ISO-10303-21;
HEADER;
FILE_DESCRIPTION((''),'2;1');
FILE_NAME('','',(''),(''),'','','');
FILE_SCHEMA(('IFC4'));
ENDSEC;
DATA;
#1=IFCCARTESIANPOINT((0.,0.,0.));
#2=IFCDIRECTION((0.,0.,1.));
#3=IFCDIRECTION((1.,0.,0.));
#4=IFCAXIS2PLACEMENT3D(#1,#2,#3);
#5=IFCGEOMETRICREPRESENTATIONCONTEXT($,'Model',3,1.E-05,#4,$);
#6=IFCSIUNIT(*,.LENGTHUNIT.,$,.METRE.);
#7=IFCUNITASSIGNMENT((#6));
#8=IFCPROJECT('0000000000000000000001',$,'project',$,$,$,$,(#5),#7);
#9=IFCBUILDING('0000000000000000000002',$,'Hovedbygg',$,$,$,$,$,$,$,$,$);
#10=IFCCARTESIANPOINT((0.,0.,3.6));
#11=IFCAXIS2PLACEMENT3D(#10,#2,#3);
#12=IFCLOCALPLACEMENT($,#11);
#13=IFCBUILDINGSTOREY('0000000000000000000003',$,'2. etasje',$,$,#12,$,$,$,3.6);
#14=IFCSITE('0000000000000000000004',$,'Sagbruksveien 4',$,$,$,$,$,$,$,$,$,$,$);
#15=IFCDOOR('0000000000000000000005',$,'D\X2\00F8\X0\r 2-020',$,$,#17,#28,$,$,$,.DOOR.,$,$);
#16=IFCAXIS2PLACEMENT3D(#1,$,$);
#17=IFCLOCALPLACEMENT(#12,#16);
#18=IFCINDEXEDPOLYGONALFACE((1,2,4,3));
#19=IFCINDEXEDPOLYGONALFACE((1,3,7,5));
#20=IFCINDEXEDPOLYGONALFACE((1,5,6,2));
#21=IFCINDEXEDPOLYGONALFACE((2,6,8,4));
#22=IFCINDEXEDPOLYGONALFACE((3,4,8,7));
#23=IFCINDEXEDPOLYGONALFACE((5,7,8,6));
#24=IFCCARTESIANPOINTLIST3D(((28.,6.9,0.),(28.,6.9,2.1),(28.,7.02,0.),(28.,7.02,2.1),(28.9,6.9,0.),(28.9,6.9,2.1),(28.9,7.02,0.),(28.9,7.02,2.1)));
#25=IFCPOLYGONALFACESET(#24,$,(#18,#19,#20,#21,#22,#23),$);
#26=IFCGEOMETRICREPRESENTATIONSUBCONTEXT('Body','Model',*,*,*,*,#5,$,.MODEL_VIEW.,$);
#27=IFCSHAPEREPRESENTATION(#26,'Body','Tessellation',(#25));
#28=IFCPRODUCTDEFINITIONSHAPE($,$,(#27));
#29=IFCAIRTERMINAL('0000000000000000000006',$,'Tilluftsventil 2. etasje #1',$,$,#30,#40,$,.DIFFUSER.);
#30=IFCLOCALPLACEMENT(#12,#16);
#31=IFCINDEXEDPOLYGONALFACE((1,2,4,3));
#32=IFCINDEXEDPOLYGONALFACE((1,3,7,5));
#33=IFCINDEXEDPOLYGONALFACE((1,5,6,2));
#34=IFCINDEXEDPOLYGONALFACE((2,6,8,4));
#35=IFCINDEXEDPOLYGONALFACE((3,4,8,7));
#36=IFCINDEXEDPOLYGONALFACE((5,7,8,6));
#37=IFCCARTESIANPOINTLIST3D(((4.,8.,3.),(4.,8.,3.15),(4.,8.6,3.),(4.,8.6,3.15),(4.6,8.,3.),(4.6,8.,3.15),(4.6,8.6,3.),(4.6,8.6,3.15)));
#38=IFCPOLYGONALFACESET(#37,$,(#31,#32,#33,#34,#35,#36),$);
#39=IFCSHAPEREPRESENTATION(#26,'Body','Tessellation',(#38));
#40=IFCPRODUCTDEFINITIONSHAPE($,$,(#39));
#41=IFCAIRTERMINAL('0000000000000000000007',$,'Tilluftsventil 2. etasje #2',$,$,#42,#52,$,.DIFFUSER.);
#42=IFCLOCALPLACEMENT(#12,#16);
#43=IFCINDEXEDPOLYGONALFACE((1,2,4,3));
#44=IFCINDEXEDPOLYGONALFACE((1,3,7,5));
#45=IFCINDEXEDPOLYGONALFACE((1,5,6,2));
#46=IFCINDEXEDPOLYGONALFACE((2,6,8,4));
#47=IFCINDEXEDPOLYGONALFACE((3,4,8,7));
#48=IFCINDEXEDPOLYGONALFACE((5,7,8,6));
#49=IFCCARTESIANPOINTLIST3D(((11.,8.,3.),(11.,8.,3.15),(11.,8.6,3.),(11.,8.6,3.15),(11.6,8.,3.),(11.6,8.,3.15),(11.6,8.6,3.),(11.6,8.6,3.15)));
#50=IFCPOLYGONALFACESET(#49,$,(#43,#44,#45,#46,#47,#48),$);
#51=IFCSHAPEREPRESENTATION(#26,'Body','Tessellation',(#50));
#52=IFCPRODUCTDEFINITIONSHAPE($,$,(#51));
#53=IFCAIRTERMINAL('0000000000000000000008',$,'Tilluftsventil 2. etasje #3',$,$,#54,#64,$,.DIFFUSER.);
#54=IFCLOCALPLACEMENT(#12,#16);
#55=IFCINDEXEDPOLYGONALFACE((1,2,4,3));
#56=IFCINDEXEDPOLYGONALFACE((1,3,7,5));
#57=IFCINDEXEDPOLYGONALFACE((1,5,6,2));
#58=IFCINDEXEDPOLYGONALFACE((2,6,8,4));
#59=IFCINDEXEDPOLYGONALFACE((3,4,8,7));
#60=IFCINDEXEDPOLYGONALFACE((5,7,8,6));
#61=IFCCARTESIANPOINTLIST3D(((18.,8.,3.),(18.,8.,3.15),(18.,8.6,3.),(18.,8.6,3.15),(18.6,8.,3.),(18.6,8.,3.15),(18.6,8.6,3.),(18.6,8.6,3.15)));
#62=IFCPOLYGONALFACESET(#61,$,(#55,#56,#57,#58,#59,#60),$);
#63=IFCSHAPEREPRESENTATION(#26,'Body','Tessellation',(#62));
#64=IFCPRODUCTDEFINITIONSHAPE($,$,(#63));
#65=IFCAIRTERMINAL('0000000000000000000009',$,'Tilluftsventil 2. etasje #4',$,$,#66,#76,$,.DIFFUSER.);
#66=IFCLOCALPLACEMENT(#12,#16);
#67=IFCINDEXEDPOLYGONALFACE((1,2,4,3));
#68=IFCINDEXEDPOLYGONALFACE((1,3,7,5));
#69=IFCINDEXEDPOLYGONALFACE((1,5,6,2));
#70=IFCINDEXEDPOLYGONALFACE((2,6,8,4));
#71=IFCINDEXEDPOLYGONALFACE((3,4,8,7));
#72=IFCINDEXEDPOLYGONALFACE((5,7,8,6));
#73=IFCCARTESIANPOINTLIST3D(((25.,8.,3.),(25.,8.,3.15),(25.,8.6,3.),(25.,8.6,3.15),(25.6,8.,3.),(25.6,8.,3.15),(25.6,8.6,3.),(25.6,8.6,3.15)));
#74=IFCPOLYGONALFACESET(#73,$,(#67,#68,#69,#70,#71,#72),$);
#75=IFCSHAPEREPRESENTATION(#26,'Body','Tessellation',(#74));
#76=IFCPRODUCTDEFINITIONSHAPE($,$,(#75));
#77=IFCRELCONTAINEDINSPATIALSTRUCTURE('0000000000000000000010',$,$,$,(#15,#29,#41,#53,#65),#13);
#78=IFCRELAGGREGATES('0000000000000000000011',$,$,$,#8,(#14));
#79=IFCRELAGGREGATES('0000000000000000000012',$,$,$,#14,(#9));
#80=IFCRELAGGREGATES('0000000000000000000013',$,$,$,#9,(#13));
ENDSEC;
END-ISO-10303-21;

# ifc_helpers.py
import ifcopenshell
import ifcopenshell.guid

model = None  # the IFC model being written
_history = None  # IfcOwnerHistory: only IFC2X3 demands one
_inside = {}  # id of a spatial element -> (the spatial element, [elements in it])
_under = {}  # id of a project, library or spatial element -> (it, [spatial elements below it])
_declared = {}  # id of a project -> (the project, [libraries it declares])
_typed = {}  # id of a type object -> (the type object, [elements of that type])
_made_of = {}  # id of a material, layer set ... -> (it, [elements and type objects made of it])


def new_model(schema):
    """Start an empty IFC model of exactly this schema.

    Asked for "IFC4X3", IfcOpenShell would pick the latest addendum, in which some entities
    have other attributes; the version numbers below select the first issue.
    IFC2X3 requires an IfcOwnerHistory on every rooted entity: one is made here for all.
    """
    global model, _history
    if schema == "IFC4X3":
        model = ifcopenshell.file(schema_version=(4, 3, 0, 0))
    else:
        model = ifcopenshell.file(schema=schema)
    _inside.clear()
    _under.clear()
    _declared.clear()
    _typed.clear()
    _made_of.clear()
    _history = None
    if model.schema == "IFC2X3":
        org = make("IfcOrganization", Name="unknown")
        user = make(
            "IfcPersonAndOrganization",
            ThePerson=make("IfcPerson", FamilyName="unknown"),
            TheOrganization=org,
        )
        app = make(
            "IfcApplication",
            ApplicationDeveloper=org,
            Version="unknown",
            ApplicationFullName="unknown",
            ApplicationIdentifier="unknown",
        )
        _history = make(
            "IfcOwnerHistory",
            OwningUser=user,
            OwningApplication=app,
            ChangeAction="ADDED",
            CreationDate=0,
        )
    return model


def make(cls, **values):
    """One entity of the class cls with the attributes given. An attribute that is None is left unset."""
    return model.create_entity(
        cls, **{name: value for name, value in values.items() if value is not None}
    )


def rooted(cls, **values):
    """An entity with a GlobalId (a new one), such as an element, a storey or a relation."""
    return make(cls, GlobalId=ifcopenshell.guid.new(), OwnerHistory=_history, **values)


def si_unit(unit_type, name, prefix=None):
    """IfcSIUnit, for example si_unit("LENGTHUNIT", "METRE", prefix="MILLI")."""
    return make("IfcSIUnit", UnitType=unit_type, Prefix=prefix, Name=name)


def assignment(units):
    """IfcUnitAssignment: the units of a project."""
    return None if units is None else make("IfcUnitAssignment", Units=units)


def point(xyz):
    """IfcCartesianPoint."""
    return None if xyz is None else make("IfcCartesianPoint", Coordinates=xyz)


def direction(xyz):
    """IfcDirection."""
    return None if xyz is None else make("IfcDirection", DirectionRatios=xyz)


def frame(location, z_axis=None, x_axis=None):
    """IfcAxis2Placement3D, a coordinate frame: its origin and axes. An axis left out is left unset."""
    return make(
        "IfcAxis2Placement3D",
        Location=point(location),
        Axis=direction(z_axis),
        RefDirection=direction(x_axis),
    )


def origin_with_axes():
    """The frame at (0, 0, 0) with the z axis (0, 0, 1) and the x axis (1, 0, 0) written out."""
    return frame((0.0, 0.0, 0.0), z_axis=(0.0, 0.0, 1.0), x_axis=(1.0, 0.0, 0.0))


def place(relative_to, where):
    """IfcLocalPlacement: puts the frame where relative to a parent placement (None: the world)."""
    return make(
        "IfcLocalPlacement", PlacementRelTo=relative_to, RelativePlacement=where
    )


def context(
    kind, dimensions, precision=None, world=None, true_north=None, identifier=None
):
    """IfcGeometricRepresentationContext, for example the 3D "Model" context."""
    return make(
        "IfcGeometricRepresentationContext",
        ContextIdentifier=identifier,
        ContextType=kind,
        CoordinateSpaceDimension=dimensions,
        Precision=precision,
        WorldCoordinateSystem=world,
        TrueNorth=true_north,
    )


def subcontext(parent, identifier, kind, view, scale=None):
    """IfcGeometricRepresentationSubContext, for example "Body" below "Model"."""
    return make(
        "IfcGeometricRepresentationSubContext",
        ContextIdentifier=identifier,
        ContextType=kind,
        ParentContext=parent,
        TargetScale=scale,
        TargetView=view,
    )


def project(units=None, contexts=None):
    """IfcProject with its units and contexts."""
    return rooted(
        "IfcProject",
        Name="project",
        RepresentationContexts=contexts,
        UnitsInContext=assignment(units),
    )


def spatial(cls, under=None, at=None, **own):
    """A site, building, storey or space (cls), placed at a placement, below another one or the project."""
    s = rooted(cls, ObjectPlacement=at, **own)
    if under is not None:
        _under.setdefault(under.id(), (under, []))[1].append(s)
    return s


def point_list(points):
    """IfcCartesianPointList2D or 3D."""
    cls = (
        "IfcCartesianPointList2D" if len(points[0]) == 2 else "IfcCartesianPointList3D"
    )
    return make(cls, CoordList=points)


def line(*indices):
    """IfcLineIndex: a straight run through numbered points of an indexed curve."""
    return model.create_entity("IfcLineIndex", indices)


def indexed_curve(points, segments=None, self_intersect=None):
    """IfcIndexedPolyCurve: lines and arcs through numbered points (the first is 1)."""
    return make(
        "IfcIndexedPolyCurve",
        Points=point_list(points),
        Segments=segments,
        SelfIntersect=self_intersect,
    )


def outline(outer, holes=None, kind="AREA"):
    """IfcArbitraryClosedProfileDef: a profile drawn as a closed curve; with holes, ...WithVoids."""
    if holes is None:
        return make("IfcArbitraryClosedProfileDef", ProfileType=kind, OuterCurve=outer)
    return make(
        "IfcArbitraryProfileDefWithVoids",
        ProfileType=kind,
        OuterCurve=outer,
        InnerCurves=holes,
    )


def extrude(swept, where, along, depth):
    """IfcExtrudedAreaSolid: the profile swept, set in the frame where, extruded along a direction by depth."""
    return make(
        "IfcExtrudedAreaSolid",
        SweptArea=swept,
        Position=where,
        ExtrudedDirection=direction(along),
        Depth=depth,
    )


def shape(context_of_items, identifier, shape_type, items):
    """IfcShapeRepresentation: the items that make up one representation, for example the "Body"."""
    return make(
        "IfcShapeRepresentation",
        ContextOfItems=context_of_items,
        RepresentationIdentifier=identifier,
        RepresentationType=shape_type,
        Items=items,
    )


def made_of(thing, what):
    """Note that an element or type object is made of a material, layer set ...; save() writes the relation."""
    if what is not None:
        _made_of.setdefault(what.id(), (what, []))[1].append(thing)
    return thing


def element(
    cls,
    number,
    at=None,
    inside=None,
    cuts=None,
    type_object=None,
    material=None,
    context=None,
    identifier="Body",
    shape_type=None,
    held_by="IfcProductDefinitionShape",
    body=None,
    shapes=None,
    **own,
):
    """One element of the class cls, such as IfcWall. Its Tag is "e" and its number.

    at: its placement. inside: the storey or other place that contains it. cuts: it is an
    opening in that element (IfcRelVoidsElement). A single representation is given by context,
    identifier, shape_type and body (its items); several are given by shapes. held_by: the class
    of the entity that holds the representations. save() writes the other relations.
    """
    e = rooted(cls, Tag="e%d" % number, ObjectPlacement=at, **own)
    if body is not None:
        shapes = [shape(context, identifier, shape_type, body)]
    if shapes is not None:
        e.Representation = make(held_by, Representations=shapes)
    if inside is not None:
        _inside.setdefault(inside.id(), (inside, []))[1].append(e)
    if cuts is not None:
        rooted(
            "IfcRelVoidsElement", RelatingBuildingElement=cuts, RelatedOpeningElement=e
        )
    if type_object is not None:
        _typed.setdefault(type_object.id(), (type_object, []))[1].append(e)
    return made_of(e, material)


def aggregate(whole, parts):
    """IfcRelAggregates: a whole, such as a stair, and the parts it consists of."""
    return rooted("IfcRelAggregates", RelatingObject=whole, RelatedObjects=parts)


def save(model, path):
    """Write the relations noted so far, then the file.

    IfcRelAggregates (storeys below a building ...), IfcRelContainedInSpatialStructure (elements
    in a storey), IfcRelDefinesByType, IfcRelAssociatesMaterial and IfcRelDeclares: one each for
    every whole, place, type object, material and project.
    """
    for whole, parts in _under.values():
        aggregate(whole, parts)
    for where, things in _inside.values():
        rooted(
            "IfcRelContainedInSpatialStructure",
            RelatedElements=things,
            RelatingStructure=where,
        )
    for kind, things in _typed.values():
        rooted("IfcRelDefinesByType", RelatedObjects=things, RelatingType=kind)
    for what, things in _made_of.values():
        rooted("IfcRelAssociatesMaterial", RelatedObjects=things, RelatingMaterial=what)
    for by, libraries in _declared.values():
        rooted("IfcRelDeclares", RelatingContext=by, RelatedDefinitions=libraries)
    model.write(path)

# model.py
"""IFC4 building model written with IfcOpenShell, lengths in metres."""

from ifc_helpers import new_model, si_unit, frame, origin_with_axes, place, context, subcontext, project, spatial, line, indexed_curve, outline, extrude, element, save


model = new_model("IFC4")

# Units and contexts
model_context = context("Model", 3, precision=1e-05, world=origin_with_axes())
body_context = subcontext(model_context, "Body", "Model", "MODEL_VIEW")
ifc_project = project(units=[si_unit("LENGTHUNIT", "METRE")], contexts=[model_context])

# Site, building, storey
site = spatial("IfcSite", under=ifc_project, Name="Sagbruksveien 4")
building = spatial("IfcBuilding", under=site, Name="Hovedbygg")
storey_placement = place(None, frame((0.0, 0.0, 3.6), z_axis=(0.0, 0.0, 1.0), x_axis=(1.0, 0.0, 0.0)))
storey = spatial("IfcBuildingStorey", under=building, at=storey_placement, Name="2. etasje", Elevation=3.6)

# Door
for number, where, z_axis, x_axis, name in (
    (1, (28.0, 6.9, 0.0), (0.0, 0.0, 1.0), (1.0, 0.0, 0.0), "Dør 2-020"),
):
    element("IfcDoor", number, at=place(storey_placement, frame(where, z_axis=z_axis, x_axis=x_axis)), inside=storey, Name=name, PredefinedType="DOOR", context=body_context, shape_type="SweptSolid", body=[
        extrude(outline(indexed_curve([(0.0, 0.0), (0.9, 0.0), (0.9, 0.12), (0.0, 0.12)], segments=[line(1, 2, 3, 4, 1)])), origin_with_axes(), (0.0, 0.0, 1.0), 2.1),
    ])

# Air terminals
for number, where, z_axis, x_axis, name in (
    (2, (4.0, 8.0, 3.0), (0.0, 0.0, 1.0), (1.0, 0.0, 0.0), "Tilluftsventil 2. etasje #1"),
    (3, (11.0, 8.0, 3.0), (0.0, 0.0, 1.0), (1.0, 0.0, 0.0), "Tilluftsventil 2. etasje #2"),
    (4, (18.0, 8.0, 3.0), (0.0, 0.0, 1.0), (1.0, 0.0, 0.0), "Tilluftsventil 2. etasje #3"),
    (5, (25.0, 8.0, 3.0), (0.0, 0.0, 1.0), (1.0, 0.0, 0.0), "Tilluftsventil 2. etasje #4"),
):
    element("IfcAirTerminal", number, at=place(storey_placement, frame(where, z_axis=z_axis, x_axis=x_axis)), inside=storey, Name=name, PredefinedType="DIFFUSER", context=body_context, shape_type="SweptSolid", body=[
        extrude(outline(indexed_curve([(0.0, 0.0), (0.6, 0.0), (0.6, 0.6), (0.0, 0.6)], segments=[line(1, 2, 3, 4, 1)])), origin_with_axes(), (0.0, 0.0, 1.0), 0.15),
    ])

save(model, "model.ifc")
